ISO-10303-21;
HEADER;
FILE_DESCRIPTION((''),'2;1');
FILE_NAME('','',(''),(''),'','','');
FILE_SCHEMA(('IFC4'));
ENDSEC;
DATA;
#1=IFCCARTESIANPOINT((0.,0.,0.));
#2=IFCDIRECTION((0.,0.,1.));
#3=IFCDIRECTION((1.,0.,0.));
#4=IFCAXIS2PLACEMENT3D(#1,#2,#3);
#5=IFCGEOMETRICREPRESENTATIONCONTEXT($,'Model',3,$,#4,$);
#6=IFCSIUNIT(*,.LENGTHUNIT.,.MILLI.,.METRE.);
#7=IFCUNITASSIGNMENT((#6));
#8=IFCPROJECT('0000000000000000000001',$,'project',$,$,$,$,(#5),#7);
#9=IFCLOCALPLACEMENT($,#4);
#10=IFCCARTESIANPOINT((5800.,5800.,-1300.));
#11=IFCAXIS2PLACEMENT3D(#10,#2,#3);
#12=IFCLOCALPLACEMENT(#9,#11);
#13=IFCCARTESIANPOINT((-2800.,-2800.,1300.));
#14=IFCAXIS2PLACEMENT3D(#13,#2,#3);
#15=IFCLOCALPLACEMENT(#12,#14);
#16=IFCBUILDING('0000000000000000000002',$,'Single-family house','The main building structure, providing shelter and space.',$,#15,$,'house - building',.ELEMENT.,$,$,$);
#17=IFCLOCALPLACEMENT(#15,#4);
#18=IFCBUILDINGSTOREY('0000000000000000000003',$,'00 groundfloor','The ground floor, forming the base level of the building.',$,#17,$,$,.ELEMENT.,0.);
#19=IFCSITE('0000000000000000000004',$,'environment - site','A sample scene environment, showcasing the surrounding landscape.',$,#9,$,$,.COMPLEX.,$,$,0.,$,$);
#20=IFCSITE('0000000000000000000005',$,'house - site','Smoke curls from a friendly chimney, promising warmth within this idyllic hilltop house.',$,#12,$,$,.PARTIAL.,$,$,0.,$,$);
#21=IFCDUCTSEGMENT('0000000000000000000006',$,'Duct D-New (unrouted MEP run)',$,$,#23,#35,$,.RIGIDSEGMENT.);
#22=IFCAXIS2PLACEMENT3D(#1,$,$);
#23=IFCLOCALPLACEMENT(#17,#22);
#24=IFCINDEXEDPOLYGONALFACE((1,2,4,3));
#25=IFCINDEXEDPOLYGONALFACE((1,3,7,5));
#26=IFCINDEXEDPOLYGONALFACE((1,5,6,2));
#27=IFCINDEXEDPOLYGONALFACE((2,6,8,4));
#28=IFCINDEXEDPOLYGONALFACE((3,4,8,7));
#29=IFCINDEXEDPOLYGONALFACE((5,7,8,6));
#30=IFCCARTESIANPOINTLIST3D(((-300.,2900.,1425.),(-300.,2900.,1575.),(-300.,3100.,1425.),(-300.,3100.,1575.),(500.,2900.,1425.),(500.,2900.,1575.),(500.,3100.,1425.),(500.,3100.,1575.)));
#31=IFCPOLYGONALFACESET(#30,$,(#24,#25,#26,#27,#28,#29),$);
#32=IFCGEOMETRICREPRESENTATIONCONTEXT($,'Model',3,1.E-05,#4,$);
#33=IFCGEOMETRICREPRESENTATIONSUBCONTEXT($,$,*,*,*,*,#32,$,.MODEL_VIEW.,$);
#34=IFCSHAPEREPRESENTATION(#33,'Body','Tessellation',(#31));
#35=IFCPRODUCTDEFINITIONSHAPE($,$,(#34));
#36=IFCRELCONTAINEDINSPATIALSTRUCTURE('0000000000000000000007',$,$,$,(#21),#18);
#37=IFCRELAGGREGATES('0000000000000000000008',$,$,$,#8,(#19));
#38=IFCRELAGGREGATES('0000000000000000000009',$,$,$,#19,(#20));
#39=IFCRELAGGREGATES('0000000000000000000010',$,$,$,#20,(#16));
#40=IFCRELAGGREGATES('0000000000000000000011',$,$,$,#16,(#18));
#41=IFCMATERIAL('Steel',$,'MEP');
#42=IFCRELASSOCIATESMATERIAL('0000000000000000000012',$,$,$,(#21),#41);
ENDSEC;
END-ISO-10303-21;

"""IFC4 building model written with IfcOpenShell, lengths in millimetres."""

from ifc_helpers import new_model, si_unit, frame, origin, origin_with_axes, origin_2d, place, context, subcontext, project, spatial, rectangle, extrude, material, element, save


model = new_model("IFC4")

# Units and contexts
model_context_1 = context("Model", 3, world=origin_with_axes())
model_context_2 = context("Model", 3, precision=1e-05, world=origin_with_axes())
sub_context = subcontext(model_context_2, None, None, "MODEL_VIEW")
ifc_project = project(units=[si_unit("LENGTHUNIT", "METRE", prefix="MILLI")], contexts=[model_context_1])

# Sites, building, storey
site_1_placement = place(None, origin_with_axes())
site_1 = spatial("IfcSite", under=ifc_project, at=site_1_placement, Name="environment - site", Description="A sample scene environment, showcasing the surrounding landscape.", CompositionType="COMPLEX", RefElevation=0.0)
site_2_placement = place(site_1_placement, frame((5800.0, 5800.0, -1300.0), z_axis=(0.0, 0.0, 1.0), x_axis=(1.0, 0.0, 0.0)))
site_2 = spatial("IfcSite", under=site_1, at=site_2_placement, Name="house - site", Description="Smoke curls from a friendly chimney, promising warmth within this idyllic hilltop house.", CompositionType="PARTIAL", RefElevation=0.0)
building_placement = place(site_2_placement, frame((-2800.0, -2800.0, 1300.0), z_axis=(0.0, 0.0, 1.0), x_axis=(1.0, 0.0, 0.0)))
building = spatial("IfcBuilding", under=site_2, at=building_placement, Name="Single-family house", Description="The main building structure, providing shelter and space.", LongName="house - building", CompositionType="ELEMENT")
storey_placement = place(building_placement, origin_with_axes())
storey = spatial("IfcBuildingStorey", under=building, at=storey_placement, Name="00 groundfloor", Description="The ground floor, forming the base level of the building.", CompositionType="ELEMENT", Elevation=0.0)

# Duct segment
ifc_material = material(Name="Steel", Category="MEP")
duct_segment_placement = place(storey_placement, frame((-300.0, 3000.0, 1500.0), z_axis=(1.0, 0.0, 0.0), x_axis=(0.0, -1.0, 0.0)))
element("IfcDuctSegment", 1, at=duct_segment_placement, inside=storey, material=ifc_material, Name="Duct D-New (unrouted MEP run)", PredefinedType="RIGIDSEGMENT", context=sub_context, shape_type="SweptSolid", body=[
    extrude(rectangle(XDim=200.0, YDim=150.0, at=origin_2d()), origin(), (0.0, 0.0, 1.0), 800.0),
])

save(model, "model.ifc")
